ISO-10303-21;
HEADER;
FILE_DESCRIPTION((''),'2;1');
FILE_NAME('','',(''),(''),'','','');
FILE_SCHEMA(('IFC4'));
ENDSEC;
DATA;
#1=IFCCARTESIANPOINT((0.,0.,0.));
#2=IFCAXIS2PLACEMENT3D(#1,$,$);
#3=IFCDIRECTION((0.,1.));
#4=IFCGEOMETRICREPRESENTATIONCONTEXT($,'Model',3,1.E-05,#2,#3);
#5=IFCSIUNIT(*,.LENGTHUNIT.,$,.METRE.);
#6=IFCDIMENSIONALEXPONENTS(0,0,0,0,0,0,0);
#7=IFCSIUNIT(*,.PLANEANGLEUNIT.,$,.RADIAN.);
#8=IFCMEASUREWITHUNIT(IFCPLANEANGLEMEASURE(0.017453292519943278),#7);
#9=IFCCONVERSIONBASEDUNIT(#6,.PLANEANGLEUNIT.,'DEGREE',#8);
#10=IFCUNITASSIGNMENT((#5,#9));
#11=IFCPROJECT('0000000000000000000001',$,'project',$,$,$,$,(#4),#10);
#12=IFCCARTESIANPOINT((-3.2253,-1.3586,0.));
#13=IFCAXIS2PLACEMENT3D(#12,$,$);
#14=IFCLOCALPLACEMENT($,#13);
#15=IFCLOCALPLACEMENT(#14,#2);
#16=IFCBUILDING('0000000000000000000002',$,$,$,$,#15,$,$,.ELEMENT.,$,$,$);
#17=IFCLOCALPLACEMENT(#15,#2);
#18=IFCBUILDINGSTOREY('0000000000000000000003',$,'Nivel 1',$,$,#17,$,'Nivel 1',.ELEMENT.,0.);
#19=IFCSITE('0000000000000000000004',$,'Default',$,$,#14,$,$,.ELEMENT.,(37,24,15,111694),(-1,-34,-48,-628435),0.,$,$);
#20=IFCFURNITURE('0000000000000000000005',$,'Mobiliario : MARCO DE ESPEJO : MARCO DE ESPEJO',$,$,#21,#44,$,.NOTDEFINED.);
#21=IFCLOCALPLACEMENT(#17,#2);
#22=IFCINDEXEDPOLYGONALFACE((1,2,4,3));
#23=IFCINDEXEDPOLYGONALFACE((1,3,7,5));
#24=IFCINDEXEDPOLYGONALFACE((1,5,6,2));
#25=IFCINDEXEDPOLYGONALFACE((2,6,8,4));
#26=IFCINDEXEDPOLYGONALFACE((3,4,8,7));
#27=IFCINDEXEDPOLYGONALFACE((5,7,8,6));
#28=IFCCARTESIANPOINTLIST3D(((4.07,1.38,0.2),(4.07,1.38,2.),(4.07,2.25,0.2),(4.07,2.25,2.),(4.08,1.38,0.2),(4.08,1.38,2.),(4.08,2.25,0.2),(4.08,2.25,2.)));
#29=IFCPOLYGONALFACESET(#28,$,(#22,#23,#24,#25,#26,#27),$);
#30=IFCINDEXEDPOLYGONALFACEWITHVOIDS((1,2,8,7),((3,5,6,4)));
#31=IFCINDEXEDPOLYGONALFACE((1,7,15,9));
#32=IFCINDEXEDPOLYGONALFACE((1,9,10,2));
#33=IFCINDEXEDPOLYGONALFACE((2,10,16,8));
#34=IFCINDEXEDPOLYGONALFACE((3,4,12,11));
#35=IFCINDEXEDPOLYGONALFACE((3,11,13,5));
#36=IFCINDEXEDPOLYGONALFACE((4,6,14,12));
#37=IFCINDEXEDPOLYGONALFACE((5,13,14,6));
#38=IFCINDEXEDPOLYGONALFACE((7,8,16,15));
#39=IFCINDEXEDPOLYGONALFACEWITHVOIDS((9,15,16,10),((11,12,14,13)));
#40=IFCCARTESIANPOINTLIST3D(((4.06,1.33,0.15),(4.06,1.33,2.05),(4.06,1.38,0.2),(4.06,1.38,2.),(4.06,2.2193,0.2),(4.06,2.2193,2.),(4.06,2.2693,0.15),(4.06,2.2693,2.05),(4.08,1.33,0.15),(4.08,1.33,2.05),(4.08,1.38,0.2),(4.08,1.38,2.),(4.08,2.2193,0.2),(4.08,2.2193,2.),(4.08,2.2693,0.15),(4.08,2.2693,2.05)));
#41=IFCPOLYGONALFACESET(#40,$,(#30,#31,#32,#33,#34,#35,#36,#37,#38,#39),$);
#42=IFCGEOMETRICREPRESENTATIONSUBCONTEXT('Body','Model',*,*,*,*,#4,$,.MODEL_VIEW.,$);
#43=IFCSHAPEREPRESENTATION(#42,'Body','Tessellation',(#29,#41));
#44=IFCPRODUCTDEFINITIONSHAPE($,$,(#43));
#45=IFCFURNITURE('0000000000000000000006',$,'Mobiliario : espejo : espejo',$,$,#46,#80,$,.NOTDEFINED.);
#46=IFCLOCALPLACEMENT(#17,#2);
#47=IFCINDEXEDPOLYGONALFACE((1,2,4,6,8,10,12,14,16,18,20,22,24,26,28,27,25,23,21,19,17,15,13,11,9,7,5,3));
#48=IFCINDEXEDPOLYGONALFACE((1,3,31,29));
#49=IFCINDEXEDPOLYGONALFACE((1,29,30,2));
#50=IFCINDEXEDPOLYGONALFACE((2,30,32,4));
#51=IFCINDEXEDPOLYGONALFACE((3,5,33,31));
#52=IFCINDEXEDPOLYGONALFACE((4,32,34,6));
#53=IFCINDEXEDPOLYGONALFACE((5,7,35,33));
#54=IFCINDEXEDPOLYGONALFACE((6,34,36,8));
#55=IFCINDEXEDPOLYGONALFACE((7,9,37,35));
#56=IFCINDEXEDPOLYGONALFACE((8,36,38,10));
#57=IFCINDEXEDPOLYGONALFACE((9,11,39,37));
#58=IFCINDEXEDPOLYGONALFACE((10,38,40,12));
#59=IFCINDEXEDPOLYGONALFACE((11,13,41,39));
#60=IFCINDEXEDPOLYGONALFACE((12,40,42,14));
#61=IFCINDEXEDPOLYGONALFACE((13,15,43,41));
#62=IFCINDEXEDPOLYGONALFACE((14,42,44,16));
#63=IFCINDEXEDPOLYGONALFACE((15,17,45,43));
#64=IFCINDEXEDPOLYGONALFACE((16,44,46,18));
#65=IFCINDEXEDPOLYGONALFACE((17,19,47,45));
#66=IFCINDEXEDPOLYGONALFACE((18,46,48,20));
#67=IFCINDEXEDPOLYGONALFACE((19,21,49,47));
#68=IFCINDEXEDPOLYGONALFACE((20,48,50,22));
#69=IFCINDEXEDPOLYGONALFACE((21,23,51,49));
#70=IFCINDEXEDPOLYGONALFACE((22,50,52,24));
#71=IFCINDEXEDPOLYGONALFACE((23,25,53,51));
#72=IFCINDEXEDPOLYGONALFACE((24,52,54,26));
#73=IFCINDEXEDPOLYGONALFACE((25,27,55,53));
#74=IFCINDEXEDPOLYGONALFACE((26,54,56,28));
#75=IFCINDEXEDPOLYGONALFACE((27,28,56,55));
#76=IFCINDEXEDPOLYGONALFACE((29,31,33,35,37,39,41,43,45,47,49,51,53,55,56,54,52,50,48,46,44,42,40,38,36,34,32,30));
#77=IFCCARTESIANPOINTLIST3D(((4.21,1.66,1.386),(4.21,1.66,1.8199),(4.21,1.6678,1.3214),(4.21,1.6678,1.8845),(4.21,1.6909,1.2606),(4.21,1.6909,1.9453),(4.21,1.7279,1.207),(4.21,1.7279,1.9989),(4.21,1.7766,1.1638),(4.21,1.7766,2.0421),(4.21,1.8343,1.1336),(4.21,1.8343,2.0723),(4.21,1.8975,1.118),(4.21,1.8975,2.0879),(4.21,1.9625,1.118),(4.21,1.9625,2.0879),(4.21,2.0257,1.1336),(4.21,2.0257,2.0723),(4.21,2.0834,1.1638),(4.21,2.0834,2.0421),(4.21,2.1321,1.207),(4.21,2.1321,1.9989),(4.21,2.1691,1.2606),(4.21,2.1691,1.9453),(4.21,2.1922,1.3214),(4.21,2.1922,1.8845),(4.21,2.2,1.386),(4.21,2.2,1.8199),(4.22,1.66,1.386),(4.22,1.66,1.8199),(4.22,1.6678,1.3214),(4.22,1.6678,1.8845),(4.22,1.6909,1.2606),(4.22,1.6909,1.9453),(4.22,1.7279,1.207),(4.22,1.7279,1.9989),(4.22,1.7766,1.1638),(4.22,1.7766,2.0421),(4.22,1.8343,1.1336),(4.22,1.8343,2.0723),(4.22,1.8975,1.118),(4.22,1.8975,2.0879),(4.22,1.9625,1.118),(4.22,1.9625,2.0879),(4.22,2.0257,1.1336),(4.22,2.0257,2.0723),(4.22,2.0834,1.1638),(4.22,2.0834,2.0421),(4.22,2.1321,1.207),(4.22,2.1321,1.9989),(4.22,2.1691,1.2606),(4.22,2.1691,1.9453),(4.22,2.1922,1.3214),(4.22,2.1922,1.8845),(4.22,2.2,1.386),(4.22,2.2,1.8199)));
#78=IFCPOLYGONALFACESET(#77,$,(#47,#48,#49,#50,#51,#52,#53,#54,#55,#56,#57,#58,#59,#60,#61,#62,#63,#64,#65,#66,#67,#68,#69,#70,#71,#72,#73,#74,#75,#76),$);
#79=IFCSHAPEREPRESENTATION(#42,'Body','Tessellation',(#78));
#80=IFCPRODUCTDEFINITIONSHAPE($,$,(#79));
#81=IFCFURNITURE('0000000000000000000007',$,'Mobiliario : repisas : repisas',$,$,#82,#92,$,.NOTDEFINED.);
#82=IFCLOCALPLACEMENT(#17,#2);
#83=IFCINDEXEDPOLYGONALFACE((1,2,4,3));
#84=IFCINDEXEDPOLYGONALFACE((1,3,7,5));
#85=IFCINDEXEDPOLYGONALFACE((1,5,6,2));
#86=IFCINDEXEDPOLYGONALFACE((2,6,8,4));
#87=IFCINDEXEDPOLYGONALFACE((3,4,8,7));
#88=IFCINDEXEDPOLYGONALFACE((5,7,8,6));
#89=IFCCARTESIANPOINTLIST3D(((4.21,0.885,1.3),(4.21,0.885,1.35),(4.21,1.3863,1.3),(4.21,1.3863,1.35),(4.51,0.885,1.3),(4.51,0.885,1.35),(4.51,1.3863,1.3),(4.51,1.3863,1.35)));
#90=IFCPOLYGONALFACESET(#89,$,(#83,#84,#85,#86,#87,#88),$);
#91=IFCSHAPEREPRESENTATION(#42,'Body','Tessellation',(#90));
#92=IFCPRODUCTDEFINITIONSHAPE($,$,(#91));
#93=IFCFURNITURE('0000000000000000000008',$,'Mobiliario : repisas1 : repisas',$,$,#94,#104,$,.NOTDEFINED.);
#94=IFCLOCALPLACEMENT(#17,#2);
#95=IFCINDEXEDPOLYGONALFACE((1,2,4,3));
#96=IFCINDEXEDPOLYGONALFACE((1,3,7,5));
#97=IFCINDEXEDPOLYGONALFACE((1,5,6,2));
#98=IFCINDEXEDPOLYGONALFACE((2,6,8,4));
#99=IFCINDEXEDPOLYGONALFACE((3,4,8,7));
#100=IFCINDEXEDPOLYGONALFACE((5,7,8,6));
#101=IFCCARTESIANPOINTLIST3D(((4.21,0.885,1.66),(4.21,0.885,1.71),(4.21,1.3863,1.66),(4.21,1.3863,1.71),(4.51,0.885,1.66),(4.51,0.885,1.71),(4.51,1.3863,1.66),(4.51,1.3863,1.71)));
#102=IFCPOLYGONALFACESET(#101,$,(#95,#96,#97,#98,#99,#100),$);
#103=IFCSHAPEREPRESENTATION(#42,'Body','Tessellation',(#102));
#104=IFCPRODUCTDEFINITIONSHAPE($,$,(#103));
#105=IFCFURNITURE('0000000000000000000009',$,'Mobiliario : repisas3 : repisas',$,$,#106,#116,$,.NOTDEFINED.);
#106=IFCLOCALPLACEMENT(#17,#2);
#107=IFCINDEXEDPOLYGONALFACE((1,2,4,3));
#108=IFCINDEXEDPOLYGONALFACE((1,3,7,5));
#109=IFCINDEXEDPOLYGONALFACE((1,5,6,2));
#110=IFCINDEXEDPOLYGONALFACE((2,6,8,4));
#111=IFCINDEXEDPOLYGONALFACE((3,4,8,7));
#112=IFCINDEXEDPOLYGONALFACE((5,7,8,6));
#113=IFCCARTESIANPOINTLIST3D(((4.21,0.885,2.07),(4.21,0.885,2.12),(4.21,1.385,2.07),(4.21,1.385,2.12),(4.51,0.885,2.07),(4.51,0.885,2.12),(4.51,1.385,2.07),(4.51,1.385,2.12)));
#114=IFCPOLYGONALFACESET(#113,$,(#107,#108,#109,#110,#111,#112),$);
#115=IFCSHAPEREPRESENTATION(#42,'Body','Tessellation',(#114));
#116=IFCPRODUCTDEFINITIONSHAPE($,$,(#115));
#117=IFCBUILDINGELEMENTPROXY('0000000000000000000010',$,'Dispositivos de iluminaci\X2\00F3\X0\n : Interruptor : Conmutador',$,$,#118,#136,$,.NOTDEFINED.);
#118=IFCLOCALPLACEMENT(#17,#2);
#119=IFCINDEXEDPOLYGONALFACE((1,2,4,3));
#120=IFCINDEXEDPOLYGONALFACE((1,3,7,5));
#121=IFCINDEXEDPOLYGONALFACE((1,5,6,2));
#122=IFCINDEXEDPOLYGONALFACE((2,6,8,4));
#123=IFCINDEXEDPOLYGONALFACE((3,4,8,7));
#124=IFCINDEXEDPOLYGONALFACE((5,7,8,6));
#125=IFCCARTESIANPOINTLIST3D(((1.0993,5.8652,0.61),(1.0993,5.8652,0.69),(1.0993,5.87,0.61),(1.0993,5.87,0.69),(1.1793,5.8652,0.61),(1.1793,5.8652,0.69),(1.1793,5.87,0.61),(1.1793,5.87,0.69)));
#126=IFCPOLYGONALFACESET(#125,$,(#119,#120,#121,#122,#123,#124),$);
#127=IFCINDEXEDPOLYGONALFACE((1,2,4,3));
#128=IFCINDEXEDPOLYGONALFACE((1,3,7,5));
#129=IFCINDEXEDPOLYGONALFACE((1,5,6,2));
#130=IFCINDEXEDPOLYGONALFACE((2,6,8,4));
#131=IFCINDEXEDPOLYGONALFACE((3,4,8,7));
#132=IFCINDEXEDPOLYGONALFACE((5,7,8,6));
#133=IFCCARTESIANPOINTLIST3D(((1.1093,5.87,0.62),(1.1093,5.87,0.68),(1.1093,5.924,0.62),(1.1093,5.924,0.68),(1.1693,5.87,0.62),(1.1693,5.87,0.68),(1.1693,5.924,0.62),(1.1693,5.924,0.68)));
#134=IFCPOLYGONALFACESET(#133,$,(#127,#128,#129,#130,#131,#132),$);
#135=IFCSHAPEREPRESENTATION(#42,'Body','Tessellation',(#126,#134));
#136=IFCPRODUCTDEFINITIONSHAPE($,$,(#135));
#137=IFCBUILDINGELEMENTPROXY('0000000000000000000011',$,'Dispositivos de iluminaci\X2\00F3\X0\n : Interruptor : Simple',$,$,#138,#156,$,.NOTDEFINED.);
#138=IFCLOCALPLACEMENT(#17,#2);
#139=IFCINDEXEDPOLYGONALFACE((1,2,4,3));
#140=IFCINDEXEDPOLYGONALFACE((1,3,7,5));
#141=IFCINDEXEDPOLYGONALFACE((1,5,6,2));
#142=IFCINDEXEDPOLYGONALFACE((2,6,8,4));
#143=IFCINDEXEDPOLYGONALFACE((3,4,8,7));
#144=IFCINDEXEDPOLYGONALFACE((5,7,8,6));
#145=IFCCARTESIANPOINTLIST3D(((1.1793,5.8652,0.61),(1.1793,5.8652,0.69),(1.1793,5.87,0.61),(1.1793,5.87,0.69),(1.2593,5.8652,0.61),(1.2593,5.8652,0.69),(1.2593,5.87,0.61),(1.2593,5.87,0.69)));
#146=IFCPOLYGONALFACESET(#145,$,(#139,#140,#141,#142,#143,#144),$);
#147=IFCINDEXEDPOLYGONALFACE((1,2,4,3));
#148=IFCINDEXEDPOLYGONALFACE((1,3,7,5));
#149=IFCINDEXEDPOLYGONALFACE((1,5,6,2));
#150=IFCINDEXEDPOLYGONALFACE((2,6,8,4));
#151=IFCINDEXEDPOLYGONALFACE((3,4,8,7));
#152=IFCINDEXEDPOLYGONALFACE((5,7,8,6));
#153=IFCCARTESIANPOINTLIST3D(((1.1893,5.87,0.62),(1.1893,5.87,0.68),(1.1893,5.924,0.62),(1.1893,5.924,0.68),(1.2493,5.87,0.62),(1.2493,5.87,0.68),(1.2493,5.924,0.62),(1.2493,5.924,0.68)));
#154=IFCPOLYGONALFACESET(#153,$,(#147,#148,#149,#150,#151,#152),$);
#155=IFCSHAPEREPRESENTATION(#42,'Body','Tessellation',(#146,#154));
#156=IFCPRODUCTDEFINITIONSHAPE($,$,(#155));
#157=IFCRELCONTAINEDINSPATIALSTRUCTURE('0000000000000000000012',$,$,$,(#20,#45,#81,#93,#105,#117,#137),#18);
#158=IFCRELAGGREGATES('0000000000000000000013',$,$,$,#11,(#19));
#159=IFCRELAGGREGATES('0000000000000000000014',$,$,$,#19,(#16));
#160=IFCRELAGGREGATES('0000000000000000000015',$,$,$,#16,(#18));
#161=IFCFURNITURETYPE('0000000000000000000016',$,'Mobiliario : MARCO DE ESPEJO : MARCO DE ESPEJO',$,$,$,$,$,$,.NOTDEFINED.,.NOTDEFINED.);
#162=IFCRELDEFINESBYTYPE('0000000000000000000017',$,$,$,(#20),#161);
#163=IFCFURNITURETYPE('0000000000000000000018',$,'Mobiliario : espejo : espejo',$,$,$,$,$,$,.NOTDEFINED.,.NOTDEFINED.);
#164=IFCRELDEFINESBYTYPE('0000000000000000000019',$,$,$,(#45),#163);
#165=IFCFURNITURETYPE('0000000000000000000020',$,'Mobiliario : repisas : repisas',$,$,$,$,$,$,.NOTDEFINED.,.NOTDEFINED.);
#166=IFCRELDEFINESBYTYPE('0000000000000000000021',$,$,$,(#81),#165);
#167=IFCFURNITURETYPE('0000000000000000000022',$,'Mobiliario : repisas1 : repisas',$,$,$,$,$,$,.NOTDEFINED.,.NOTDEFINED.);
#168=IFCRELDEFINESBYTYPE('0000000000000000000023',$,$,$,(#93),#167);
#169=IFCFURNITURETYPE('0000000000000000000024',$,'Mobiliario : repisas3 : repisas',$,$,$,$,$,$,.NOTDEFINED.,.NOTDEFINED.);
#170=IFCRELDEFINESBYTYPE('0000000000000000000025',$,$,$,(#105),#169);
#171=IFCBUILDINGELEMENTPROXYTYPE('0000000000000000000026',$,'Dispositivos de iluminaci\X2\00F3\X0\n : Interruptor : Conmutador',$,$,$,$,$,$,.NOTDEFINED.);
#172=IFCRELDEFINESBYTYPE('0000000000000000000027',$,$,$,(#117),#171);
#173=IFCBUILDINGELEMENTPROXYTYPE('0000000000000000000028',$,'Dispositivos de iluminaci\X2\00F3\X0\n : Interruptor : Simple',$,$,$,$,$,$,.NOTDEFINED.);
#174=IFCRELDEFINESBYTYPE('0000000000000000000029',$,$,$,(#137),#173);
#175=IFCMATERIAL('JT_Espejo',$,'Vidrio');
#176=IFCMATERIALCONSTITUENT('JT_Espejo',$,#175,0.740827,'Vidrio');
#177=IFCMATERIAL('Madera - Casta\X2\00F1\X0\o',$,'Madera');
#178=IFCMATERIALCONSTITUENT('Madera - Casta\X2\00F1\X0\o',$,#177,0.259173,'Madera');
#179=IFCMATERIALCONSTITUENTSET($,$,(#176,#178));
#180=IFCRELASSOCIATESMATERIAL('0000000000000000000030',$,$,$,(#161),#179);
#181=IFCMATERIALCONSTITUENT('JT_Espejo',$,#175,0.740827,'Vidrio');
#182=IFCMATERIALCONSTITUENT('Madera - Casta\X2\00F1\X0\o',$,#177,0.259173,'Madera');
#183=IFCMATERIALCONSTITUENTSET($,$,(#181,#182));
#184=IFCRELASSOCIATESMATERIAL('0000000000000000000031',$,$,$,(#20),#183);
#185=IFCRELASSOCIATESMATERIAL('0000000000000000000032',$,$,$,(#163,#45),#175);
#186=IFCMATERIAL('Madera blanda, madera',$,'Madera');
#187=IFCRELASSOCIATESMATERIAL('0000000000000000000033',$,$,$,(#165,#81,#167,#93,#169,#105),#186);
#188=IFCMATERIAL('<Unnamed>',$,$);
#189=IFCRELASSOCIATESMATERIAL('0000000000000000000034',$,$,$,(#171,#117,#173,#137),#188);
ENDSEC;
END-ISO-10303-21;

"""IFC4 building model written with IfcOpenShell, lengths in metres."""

from ifc_helpers import new_model, entity, si_unit, converted_unit, direction, frame, origin, place, context, subcontext, project, spatial, line, arc, indexed_curve, outline, extrude, source, transform, mapped, material, constituent, constituent_set, type_object, type_shapes, element, save


model = new_model("IFC4")

# Units and contexts
model_context = context("Model", 3, precision=1e-05, world=origin(), true_north=direction((0.0, 1.0)))
body_context = subcontext(model_context, "Body", "Model", "MODEL_VIEW")
ifc_project = project(units=[si_unit("LENGTHUNIT", "METRE"), converted_unit("PLANEANGLEUNIT", "DEGREE", entity("IfcPlaneAngleMeasure", 0.017453292519943278), si_unit("PLANEANGLEUNIT", "RADIAN"), dimensions=[0, 0, 0, 0, 0, 0, 0])], contexts=[model_context])

# Site, building, storey
site_placement = place(None, frame((-3.2253, -1.3586, 0.0)))
site = spatial("IfcSite", under=ifc_project, at=site_placement, Name="Default", CompositionType="ELEMENT", RefLatitude=(37, 24, 15, 111694), RefLongitude=(-1, -34, -48, -628435), RefElevation=0.0)
building_placement = place(site_placement, origin())
building = spatial("IfcBuilding", under=site, at=building_placement, CompositionType="ELEMENT")
storey_placement = place(building_placement, origin())
storey = spatial("IfcBuildingStorey", under=building, at=storey_placement, Name="Nivel 1", LongName="Nivel 1", CompositionType="ELEMENT", Elevation=0.0)

# Shared definitions
ifc_material_1 = material(Name="Madera blanda, madera", Category="Madera")

# Furniture
ifc_material_2 = material(Name="JT_Espejo", Category="Vidrio")
ifc_constituent_1 = constituent(ifc_material_2, Name="JT_Espejo", Category="Vidrio", fraction=0.740827)
ifc_material_3 = material(Name="Madera - Castaño", Category="Madera")
ifc_constituent_2 = constituent(ifc_material_3, Name="Madera - Castaño", Category="Madera", fraction=0.259173)
ifc_constituent_set_1 = constituent_set(constituents=[ifc_constituent_1, ifc_constituent_2])
ifc_constituent_3 = constituent(ifc_material_2, Name="JT_Espejo", Category="Vidrio", fraction=0.740827)
ifc_constituent_4 = constituent(ifc_material_3, Name="Madera - Castaño", Category="Madera", fraction=0.259173)
ifc_constituent_set_2 = constituent_set(constituents=[ifc_constituent_3, ifc_constituent_4])
furniture_type_1 = type_object("IfcFurnitureType", Name="Mobiliario : MARCO DE ESPEJO : MARCO DE ESPEJO", AssemblyPlace="NOTDEFINED", PredefinedType="NOTDEFINED", material=ifc_constituent_set_2)
shared_shape_1 = source(origin(), body_context, "Body", "SweptSolid", [
    extrude(outline(indexed_curve([(-0.005, -0.435), (0.005, -0.435), (0.005, 0.435), (-0.005, 0.435), (-0.005, -0.435)], self_intersect=False)), frame((4.075, 1.815, 0.2), z_axis=(0.0, 0.0, 1.0), x_axis=(-1.0, 0.0, 0.0)), (0.0, 0.0, 1.0), 1.8),
    extrude(outline(indexed_curve([(-0.95, -0.4696), (0.95, -0.4696), (0.95, 0.4696), (-0.95, 0.4696), (-0.95, -0.4696)], self_intersect=False), holes=[indexed_curve([(-0.9, -0.4196), (-0.9, 0.4196), (0.9, 0.4196), (0.9, -0.4196), (-0.9, -0.4196)], self_intersect=False)]), frame((4.06, 1.7996, 1.1), z_axis=(1.0, 0.0, 0.0), x_axis=(0.0, 0.0, -1.0)), (0.0, 0.0, 1.0), 0.02),
])
type_shapes(furniture_type_1, [shared_shape_1])
furniture_1_placement = place(storey_placement, origin())
element("IfcFurniture", 1, at=furniture_1_placement, inside=storey, type_object=furniture_type_1, material=ifc_constituent_set_1, Name="Mobiliario : MARCO DE ESPEJO : MARCO DE ESPEJO", PredefinedType="NOTDEFINED", context=body_context, shape_type="MappedRepresentation", body=[
    mapped(shared_shape_1, transform((0.0, 0.0, 0.0), scale=1.0)),
])
furniture_type_2 = type_object("IfcFurnitureType", Name="Mobiliario : espejo : espejo", AssemblyPlace="NOTDEFINED", PredefinedType="NOTDEFINED", material=ifc_material_2)
shared_shape_2 = source(origin(), body_context, "Body", "SweptSolid", [
    extrude(outline(indexed_curve([(-0.2169, -0.27), (0.2169, -0.27), (0.4869, 0.0), (0.2169, 0.27), (-0.2169, 0.27), (-0.4869, 0.0)], segments=[line(1, 2), arc(2, 3, 4), line(4, 5), arc(5, 6, 1)], self_intersect=False)), frame((4.21, 1.93, 1.6029), z_axis=(1.0, 0.0, 0.0), x_axis=(0.0, 0.0, -1.0)), (0.0, 0.0, 1.0), 0.01),
])
type_shapes(furniture_type_2, [shared_shape_2])
furniture_2_placement = place(storey_placement, origin())
element("IfcFurniture", 2, at=furniture_2_placement, inside=storey, type_object=furniture_type_2, material=ifc_material_2, Name="Mobiliario : espejo : espejo", PredefinedType="NOTDEFINED", context=body_context, shape_type="MappedRepresentation", body=[
    mapped(shared_shape_2, transform((0.0, 0.0, 0.0), scale=1.0)),
])
furniture_type_3 = type_object("IfcFurnitureType", Name="Mobiliario : repisas : repisas", AssemblyPlace="NOTDEFINED", PredefinedType="NOTDEFINED", material=ifc_material_1)
shared_shape_3 = source(origin(), body_context, "Body", "SweptSolid", [
    extrude(outline(indexed_curve([(-0.15, -0.2507), (0.15, -0.2507), (0.15, 0.2507), (-0.15, 0.2507), (-0.15, -0.2507)], self_intersect=False)), frame((4.36, 1.1357, 1.3), z_axis=(0.0, 0.0, 1.0), x_axis=(-1.0, 0.0, 0.0)), (0.0, 0.0, 1.0), 0.05),
])
type_shapes(furniture_type_3, [shared_shape_3])
furniture_3_placement = place(storey_placement, origin())
element("IfcFurniture", 3, at=furniture_3_placement, inside=storey, type_object=furniture_type_3, material=ifc_material_1, Name="Mobiliario : repisas : repisas", PredefinedType="NOTDEFINED", context=body_context, shape_type="MappedRepresentation", body=[
    mapped(shared_shape_3, transform((0.0, 0.0, 0.0), scale=1.0)),
])
furniture_type_4 = type_object("IfcFurnitureType", Name="Mobiliario : repisas1 : repisas", AssemblyPlace="NOTDEFINED", PredefinedType="NOTDEFINED", material=ifc_material_1)
shared_shape_4 = source(origin(), body_context, "Body", "SweptSolid", [
    extrude(outline(indexed_curve([(-0.15, -0.2507), (0.15, -0.2507), (0.15, 0.2507), (-0.15, 0.2507), (-0.15, -0.2507)], self_intersect=False)), frame((4.36, 1.1357, 1.66), z_axis=(0.0, 0.0, 1.0), x_axis=(-1.0, 0.0, 0.0)), (0.0, 0.0, 1.0), 0.05),
])
type_shapes(furniture_type_4, [shared_shape_4])
furniture_4_placement = place(storey_placement, origin())
element("IfcFurniture", 4, at=furniture_4_placement, inside=storey, type_object=furniture_type_4, material=ifc_material_1, Name="Mobiliario : repisas1 : repisas", PredefinedType="NOTDEFINED", context=body_context, shape_type="MappedRepresentation", body=[
    mapped(shared_shape_4, transform((0.0, 0.0, 0.0), scale=1.0)),
])
furniture_type_5 = type_object("IfcFurnitureType", Name="Mobiliario : repisas3 : repisas", AssemblyPlace="NOTDEFINED", PredefinedType="NOTDEFINED", material=ifc_material_1)
shared_shape_5 = source(origin(), body_context, "Body", "SweptSolid", [
    extrude(outline(indexed_curve([(-0.15, -0.25), (0.15, -0.25), (0.15, 0.25), (-0.15, 0.25), (-0.15, -0.25)], self_intersect=False)), frame((4.36, 1.135, 2.07), z_axis=(0.0, 0.0, 1.0), x_axis=(-1.0, 0.0, 0.0)), (0.0, 0.0, 1.0), 0.05),
])
type_shapes(furniture_type_5, [shared_shape_5])
furniture_5_placement = place(storey_placement, origin())
element("IfcFurniture", 5, at=furniture_5_placement, inside=storey, type_object=furniture_type_5, material=ifc_material_1, Name="Mobiliario : repisas3 : repisas", PredefinedType="NOTDEFINED", context=body_context, shape_type="MappedRepresentation", body=[
    mapped(shared_shape_5, transform((0.0, 0.0, 0.0), scale=1.0)),
])

# Building element proxies
ifc_material_4 = material(Name="<Unnamed>")
building_element_proxy_type_1 = type_object("IfcBuildingElementProxyType", Name="Dispositivos de iluminación : Interruptor : Conmutador", PredefinedType="NOTDEFINED", material=ifc_material_4)
shared_shape_6 = source(origin(), body_context, "Body", "SweptSolid", [
    extrude(outline(indexed_curve([(-0.04, -0.04), (0.04, -0.04), (0.04, 0.04), (-0.04, 0.04), (-0.04, -0.04)], self_intersect=False)), frame((0.0, 0.0, 0.0), z_axis=(0.0, 0.0, 1.0), x_axis=(0.0, -1.0, 0.0)), (0.0, 0.0, 1.0), 0.0048),
    extrude(outline(indexed_curve([(-0.03, -0.03), (0.03, -0.03), (0.03, 0.03), (-0.03, 0.03), (-0.03, -0.03)], self_intersect=False)), frame((0.0, 0.0, -0.054), z_axis=(0.0, 0.0, 1.0), x_axis=(-1.0, 0.0, 0.0)), (0.0, 0.0, 1.0), 0.054),
])
type_shapes(building_element_proxy_type_1, [shared_shape_6])
proxy_1_placement = place(storey_placement, frame((1.1393, 5.87, 0.65), z_axis=(0.0, -1.0, 0.0), x_axis=(1.0, 0.0, 0.0)))
element("IfcBuildingElementProxy", 6, at=proxy_1_placement, inside=storey, type_object=building_element_proxy_type_1, material=ifc_material_4, Name="Dispositivos de iluminación : Interruptor : Conmutador", PredefinedType="NOTDEFINED", context=body_context, shape_type="MappedRepresentation", body=[
    mapped(shared_shape_6, transform((0.0, 0.0, 0.0), scale=1.0)),
])
building_element_proxy_type_2 = type_object("IfcBuildingElementProxyType", Name="Dispositivos de iluminación : Interruptor : Simple", PredefinedType="NOTDEFINED", material=ifc_material_4)
shared_shape_7 = source(origin(), body_context, "Body", "SweptSolid", [
    extrude(outline(indexed_curve([(-0.04, -0.04), (0.04, -0.04), (0.04, 0.04), (-0.04, 0.04), (-0.04, -0.04)], self_intersect=False)), frame((0.0, 0.0, 0.0), z_axis=(0.0, 0.0, 1.0), x_axis=(0.0, -1.0, 0.0)), (0.0, 0.0, 1.0), 0.0048),
    extrude(outline(indexed_curve([(-0.03, -0.03), (0.03, -0.03), (0.03, 0.03), (-0.03, 0.03), (-0.03, -0.03)], self_intersect=False)), frame((0.0, 0.0, -0.054), z_axis=(0.0, 0.0, 1.0), x_axis=(-1.0, 0.0, 0.0)), (0.0, 0.0, 1.0), 0.054),
])
type_shapes(building_element_proxy_type_2, [shared_shape_7])
proxy_2_placement = place(storey_placement, frame((1.2193, 5.87, 0.65), z_axis=(0.0, -1.0, 0.0), x_axis=(1.0, 0.0, 0.0)))
element("IfcBuildingElementProxy", 7, at=proxy_2_placement, inside=storey, type_object=building_element_proxy_type_2, material=ifc_material_4, Name="Dispositivos de iluminación : Interruptor : Simple", PredefinedType="NOTDEFINED", context=body_context, shape_type="MappedRepresentation", body=[
    mapped(shared_shape_7, transform((0.0, 0.0, 0.0), scale=1.0)),
])

save(model, "model.ifc")
